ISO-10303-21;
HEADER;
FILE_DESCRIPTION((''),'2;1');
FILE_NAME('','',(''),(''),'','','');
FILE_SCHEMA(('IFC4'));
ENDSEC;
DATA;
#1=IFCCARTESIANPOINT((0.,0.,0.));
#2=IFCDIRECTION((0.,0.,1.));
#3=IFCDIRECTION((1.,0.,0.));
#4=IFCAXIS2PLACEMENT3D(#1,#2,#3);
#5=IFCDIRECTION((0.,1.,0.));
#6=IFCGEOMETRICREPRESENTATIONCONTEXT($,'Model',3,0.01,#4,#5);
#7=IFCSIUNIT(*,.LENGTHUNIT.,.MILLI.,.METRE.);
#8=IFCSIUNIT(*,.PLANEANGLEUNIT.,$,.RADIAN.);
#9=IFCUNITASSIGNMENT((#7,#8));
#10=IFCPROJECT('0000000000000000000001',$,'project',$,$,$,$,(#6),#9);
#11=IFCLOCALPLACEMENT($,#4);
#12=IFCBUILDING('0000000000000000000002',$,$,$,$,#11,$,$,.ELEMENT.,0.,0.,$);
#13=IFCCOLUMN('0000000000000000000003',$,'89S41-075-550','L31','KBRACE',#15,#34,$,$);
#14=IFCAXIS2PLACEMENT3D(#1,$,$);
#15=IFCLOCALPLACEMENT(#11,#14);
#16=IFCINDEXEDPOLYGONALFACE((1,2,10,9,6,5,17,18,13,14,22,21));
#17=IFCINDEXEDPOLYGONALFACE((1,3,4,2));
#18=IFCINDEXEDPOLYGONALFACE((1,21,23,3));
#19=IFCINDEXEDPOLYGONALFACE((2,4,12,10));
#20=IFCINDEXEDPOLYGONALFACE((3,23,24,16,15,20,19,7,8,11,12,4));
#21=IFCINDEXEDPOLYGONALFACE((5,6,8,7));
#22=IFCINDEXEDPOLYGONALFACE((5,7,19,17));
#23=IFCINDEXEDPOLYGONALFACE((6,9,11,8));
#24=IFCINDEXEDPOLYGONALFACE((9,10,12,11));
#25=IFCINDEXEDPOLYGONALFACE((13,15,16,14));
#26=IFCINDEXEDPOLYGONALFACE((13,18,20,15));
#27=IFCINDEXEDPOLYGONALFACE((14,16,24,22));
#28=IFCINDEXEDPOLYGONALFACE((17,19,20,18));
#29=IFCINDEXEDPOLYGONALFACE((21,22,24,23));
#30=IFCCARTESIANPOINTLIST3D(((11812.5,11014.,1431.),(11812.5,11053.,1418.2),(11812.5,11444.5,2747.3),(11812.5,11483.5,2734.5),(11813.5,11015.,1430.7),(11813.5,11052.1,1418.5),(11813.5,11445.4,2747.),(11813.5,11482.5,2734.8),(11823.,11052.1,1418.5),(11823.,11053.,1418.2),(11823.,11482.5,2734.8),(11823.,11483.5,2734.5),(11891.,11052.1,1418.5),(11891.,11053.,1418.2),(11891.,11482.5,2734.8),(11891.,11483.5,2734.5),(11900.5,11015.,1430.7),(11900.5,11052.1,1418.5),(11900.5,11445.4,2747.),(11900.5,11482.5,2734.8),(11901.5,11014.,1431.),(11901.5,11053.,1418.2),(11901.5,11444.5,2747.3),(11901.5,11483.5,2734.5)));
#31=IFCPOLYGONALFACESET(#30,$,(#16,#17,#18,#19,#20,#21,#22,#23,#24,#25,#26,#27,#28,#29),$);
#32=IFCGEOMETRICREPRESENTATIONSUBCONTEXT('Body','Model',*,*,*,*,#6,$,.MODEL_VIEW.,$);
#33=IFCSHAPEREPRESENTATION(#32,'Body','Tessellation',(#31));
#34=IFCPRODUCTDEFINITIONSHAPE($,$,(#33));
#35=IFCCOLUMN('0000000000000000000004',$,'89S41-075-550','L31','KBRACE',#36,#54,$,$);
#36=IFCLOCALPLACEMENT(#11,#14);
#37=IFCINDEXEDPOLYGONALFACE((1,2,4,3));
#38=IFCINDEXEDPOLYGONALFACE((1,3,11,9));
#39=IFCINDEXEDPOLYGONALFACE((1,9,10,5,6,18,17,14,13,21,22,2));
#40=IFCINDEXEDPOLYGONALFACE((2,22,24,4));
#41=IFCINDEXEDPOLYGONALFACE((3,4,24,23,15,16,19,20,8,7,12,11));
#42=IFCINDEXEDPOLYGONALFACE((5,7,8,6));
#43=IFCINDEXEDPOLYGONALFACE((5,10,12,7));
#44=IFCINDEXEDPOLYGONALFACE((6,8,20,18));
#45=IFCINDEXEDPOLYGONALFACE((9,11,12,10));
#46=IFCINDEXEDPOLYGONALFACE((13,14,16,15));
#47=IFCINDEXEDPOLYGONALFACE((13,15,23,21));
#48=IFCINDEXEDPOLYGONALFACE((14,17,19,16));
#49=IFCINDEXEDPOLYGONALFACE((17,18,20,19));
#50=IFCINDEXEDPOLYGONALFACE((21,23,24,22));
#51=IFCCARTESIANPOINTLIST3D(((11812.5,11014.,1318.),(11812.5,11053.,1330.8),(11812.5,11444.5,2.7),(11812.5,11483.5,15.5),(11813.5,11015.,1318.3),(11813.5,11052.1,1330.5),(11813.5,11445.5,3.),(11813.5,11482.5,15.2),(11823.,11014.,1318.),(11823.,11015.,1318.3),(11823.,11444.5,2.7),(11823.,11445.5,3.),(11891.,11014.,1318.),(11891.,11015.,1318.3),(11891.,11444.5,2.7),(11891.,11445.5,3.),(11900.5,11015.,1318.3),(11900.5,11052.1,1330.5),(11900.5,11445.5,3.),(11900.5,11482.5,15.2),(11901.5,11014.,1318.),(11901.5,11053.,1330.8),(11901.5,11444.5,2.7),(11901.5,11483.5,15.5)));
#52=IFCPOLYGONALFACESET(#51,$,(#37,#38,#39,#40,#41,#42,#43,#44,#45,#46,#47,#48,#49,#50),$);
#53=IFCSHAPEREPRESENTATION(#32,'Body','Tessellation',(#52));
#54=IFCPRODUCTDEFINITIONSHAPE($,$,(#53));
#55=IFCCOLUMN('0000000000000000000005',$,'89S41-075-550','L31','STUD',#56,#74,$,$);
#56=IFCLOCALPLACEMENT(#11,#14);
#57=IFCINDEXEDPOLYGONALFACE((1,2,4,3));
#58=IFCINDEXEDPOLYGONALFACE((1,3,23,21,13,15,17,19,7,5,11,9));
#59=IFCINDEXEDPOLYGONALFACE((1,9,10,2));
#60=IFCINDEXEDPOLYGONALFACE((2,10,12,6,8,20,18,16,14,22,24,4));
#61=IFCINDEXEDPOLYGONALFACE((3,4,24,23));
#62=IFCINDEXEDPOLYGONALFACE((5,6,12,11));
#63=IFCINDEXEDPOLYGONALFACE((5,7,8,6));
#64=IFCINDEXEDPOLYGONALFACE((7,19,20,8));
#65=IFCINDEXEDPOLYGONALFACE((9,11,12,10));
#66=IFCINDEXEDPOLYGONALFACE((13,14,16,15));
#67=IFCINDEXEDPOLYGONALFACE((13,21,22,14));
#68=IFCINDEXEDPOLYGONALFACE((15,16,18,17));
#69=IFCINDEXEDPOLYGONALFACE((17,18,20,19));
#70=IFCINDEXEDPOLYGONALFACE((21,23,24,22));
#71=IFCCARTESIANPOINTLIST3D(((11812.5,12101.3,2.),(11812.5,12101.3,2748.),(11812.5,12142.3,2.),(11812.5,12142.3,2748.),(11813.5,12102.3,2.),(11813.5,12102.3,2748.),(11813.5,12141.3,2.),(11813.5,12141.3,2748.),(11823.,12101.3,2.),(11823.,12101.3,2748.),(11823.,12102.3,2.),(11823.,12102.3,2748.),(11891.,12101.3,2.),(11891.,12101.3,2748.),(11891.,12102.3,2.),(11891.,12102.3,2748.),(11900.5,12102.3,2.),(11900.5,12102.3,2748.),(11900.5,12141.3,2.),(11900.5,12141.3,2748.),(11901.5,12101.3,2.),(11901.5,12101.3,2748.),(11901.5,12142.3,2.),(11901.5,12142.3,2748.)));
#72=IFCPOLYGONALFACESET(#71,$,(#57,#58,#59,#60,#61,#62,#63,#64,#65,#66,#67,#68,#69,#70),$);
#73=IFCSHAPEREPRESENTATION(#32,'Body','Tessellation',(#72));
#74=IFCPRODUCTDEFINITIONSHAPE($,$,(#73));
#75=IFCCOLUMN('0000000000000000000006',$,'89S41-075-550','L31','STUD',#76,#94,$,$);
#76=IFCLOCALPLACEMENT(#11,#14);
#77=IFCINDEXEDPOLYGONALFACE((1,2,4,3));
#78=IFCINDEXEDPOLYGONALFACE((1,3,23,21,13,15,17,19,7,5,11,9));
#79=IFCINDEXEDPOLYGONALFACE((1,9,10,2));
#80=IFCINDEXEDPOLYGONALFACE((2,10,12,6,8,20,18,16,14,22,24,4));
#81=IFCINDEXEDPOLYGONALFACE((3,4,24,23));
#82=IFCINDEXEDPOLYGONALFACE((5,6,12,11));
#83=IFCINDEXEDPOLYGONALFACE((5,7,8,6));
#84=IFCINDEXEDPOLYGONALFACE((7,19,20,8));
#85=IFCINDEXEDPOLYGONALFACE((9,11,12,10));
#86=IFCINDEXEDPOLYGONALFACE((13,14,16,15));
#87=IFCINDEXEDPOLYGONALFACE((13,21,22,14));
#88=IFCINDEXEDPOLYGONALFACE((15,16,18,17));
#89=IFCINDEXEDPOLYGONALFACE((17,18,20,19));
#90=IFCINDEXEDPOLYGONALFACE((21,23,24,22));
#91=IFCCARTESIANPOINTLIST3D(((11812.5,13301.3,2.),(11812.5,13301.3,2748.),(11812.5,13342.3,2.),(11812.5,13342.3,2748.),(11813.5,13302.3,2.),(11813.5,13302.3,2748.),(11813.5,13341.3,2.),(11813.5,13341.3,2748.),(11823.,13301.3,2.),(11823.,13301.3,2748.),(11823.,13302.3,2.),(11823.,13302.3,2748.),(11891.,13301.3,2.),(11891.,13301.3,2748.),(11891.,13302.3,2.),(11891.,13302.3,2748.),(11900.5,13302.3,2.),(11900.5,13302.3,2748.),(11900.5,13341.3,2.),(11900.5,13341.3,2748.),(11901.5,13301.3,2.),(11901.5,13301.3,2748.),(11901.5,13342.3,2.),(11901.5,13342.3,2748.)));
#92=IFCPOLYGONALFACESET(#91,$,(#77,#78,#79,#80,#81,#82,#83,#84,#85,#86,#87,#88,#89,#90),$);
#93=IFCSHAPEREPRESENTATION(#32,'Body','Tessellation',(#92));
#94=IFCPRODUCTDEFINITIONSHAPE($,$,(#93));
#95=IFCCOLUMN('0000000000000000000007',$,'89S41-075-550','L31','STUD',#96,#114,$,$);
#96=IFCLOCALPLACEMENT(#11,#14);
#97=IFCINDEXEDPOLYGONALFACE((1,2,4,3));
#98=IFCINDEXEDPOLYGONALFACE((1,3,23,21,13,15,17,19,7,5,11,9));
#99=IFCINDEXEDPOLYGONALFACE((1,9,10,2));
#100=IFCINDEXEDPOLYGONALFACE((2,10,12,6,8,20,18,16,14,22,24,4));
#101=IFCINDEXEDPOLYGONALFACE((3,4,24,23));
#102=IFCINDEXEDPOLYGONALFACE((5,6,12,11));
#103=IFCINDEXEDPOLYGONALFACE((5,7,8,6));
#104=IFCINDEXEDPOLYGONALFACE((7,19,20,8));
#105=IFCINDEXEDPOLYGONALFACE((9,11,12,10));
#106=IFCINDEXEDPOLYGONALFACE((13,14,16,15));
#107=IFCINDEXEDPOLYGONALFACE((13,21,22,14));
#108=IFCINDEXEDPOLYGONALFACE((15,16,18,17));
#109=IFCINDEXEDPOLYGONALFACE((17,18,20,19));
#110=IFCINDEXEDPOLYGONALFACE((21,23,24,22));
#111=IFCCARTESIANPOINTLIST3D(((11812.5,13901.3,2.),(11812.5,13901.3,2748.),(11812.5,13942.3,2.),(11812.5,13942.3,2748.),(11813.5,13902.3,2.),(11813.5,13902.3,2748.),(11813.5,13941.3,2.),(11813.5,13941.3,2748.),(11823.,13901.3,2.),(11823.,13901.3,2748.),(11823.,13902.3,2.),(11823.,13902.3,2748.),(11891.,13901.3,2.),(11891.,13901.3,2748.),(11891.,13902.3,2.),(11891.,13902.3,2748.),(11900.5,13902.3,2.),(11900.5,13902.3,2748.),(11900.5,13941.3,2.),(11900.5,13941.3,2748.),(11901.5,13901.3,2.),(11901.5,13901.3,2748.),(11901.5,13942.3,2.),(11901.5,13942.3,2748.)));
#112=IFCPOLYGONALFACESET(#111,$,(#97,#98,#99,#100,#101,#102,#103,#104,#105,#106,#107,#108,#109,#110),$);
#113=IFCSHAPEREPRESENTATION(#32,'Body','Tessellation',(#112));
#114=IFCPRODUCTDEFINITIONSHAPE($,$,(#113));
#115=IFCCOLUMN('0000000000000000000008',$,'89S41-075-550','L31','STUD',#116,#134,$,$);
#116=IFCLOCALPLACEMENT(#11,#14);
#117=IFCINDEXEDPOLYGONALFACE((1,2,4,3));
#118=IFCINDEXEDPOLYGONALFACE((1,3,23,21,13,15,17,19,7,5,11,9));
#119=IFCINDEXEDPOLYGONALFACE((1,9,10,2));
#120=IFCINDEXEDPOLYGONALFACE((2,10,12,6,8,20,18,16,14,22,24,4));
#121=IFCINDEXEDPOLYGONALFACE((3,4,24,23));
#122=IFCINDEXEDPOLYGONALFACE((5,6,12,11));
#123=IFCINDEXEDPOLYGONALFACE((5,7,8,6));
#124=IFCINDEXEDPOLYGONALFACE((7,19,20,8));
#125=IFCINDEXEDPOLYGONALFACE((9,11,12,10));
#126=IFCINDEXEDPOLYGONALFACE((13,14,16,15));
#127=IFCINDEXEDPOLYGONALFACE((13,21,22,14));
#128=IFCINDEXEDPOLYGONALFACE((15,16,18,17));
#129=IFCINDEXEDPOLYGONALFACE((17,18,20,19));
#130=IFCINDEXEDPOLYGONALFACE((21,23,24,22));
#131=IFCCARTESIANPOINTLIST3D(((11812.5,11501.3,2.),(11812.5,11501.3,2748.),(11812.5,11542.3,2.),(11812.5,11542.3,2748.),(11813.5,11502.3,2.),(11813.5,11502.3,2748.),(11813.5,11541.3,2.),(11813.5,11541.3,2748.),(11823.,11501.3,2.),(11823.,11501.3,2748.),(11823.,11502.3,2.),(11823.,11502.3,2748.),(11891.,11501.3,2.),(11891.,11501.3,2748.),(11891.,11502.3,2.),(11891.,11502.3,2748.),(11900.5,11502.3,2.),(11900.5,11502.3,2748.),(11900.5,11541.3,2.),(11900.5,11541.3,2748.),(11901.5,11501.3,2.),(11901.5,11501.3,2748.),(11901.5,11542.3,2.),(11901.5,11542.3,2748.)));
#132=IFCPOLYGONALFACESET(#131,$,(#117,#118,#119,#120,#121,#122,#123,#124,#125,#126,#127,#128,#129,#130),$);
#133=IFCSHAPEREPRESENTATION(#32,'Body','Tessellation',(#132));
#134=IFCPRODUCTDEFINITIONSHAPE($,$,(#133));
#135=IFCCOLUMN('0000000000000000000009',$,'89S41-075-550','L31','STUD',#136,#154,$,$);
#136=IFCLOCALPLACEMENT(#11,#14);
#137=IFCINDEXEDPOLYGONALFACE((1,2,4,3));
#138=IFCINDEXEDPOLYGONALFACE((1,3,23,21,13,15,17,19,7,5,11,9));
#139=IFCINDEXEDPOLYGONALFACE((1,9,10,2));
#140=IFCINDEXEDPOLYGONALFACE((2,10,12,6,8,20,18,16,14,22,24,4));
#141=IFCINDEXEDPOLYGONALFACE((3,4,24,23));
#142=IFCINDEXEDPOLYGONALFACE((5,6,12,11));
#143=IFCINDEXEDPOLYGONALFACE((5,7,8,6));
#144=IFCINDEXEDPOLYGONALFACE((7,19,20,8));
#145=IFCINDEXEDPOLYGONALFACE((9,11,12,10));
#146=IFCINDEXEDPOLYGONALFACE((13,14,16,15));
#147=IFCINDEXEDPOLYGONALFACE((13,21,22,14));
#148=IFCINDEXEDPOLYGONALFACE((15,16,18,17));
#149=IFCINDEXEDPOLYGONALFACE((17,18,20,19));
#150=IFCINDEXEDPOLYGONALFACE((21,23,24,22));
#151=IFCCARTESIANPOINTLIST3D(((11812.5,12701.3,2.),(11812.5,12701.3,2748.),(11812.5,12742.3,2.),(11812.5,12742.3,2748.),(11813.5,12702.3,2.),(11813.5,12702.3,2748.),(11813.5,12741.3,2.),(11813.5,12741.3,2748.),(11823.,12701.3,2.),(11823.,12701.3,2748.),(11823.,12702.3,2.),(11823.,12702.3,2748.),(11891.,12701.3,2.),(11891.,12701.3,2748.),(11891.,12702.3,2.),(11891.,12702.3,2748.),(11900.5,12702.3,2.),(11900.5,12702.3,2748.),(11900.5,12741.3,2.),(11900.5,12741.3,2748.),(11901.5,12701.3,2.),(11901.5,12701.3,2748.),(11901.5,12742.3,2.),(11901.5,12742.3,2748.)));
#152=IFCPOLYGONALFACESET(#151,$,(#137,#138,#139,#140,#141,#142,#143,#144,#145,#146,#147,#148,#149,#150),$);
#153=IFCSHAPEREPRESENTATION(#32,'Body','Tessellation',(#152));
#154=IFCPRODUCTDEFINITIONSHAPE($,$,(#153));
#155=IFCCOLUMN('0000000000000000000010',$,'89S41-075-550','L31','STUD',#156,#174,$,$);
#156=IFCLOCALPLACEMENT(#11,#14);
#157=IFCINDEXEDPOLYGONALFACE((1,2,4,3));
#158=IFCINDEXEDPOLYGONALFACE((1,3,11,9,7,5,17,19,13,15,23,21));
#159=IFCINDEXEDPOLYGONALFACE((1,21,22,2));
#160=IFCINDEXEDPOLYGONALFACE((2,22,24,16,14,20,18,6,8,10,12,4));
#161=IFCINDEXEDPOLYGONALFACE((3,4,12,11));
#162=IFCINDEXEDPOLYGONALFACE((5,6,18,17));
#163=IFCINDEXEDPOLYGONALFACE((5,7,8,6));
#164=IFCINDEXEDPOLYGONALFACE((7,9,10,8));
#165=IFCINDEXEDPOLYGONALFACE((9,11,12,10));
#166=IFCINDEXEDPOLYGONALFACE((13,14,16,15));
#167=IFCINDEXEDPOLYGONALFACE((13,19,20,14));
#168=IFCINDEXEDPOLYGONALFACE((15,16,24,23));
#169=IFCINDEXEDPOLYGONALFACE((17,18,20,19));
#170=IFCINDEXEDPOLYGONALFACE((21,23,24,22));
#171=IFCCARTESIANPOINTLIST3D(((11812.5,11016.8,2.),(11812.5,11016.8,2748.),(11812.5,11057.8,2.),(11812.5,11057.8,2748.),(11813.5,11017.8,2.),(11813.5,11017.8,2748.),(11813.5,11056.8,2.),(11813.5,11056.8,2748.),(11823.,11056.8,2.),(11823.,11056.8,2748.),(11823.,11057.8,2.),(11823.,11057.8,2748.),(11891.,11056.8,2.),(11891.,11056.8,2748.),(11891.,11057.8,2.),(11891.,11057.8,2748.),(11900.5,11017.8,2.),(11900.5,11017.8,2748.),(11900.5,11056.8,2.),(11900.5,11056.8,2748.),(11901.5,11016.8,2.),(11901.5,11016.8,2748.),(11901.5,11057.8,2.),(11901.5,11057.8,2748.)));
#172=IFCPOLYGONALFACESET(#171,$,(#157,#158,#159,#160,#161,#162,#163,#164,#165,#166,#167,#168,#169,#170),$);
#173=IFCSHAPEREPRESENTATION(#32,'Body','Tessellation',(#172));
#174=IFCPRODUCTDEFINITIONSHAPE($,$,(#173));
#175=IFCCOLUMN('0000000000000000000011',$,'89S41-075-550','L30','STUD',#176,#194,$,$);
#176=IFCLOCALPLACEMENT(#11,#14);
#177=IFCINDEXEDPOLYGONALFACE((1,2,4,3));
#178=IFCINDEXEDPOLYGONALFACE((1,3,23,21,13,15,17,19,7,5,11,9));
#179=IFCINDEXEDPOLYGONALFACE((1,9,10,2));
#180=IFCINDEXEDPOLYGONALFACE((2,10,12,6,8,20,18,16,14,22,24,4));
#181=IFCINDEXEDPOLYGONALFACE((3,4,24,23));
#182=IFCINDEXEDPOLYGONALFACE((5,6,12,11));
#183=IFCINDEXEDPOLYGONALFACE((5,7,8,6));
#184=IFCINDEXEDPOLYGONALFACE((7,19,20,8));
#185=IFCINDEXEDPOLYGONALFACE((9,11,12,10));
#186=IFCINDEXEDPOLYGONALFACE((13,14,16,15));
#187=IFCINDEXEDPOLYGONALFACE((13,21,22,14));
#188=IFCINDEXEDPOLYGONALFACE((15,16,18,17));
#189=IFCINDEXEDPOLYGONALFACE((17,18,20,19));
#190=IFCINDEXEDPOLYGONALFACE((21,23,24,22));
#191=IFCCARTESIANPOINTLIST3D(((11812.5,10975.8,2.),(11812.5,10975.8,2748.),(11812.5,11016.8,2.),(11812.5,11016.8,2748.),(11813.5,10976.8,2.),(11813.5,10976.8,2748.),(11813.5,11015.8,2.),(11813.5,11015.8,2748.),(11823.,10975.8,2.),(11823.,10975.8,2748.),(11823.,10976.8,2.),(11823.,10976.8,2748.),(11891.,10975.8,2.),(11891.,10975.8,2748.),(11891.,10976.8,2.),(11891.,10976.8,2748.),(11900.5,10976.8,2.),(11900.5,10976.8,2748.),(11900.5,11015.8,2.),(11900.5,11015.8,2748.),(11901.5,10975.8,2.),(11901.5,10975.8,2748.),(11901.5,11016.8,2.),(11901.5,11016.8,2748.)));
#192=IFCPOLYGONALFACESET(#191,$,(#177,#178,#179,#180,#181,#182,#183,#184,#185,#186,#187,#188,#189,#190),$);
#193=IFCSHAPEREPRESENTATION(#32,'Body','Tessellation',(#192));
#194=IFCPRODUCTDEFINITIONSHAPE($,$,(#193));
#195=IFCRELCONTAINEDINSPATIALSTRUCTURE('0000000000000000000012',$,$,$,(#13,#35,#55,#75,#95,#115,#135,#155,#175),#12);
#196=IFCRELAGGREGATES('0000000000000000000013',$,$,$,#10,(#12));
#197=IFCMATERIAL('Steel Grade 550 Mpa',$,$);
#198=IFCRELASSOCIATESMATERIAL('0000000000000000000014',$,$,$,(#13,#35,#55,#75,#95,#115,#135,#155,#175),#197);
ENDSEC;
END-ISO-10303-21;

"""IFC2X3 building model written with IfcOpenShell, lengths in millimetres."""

from ifc_helpers import new_model, si_unit, direction, frame, origin, origin_with_axes, origin_2d_with_axis, place, context, subcontext, project, spatial, c_section, extrude, source, transform, mapped, material, element, save


model = new_model("IFC2X3")

# Units and contexts
model_context = context("Model", 3, precision=0.01, world=origin_with_axes(), true_north=direction((0.0, 1.0, 0.0)))
body_context = subcontext(model_context, "Body", "Model", "MODEL_VIEW")
ifc_project = project(units=[si_unit("LENGTHUNIT", "METRE", prefix="MILLI"), si_unit("PLANEANGLEUNIT", "RADIAN")], contexts=[model_context])

# Building
building_placement = place(None, origin_with_axes())
building = spatial("IfcBuilding", under=ifc_project, at=building_placement, CompositionType="ELEMENT", ElevationOfRefHeight=0.0, ElevationOfTerrain=0.0)

# Columns
ifc_material = material(Name="Steel Grade 550 Mpa")
shared_shape_1 = source(origin(), body_context, "Body", "SweptSolid", [
    extrude(c_section(Depth=89.0, Width=41.0, WallThickness=1.0, Girth=10.5, at=origin_2d_with_axis()), origin_with_axes(), (0.0, 0.0, 1.0), 1384.9),
])
column_1_placement = place(None, frame((11857.0, 11033.5, 1424.6), z_axis=(0.0, 0.310822, 0.950468), x_axis=(0.0, 0.950468, -0.310822)))
element("IfcColumn", 1, at=column_1_placement, inside=building, material=ifc_material, Name="89S41-075-550", Description="L31", ObjectType="KBRACE", context=body_context, shape_type="MappedRepresentation", body=[
    mapped(shared_shape_1, transform((0.0, 0.0, 0.0), scale=1.0)),
])
shared_shape_2 = source(origin(), body_context, "Body", "SweptSolid", [
    extrude(c_section(Depth=89.0, Width=41.0, WallThickness=1.0, Girth=10.5, at=origin_2d_with_axis()), origin_with_axes(), (0.0, 0.0, 1.0), 1384.0),
])
column_2_placement = place(None, frame((11857.0, 11464.0, 9.1), z_axis=(0.0, -0.31104, 0.950397), x_axis=(0.0, -0.950397, -0.31104)))
element("IfcColumn", 2, at=column_2_placement, inside=building, material=ifc_material, Name="89S41-075-550", Description="L31", ObjectType="KBRACE", context=body_context, shape_type="MappedRepresentation", body=[
    mapped(shared_shape_2, transform((0.0, 0.0, 0.0), scale=1.0)),
])
shared_shape_3 = source(origin(), body_context, "Body", "SweptSolid", [
    extrude(c_section(Depth=89.0, Width=41.0, WallThickness=1.0, Girth=10.5, at=origin_2d_with_axis()), origin_with_axes(), (0.0, 0.0, 1.0), 2746.0),
])
column_3_placement = place(None, frame((11857.0, 12121.8, 2.0), z_axis=(0.0, 0.0, 1.0), x_axis=(0.0, -1.0, 0.0)))
element("IfcColumn", 3, at=column_3_placement, inside=building, material=ifc_material, Name="89S41-075-550", Description="L31", ObjectType="STUD", context=body_context, shape_type="MappedRepresentation", body=[
    mapped(shared_shape_3, transform((0.0, 0.0, 0.0), scale=1.0)),
])
shared_shape_4 = source(origin(), body_context, "Body", "SweptSolid", [
    extrude(c_section(Depth=89.0, Width=41.0, WallThickness=1.0, Girth=10.5, at=origin_2d_with_axis()), origin_with_axes(), (0.0, 0.0, 1.0), 2746.0),
])
column_4_placement = place(None, frame((11857.0, 13321.8, 2.0), z_axis=(0.0, 0.0, 1.0), x_axis=(0.0, -1.0, 0.0)))
element("IfcColumn", 4, at=column_4_placement, inside=building, material=ifc_material, Name="89S41-075-550", Description="L31", ObjectType="STUD", context=body_context, shape_type="MappedRepresentation", body=[
    mapped(shared_shape_4, transform((0.0, 0.0, 0.0), scale=1.0)),
])
shared_shape_5 = source(origin(), body_context, "Body", "SweptSolid", [
    extrude(c_section(Depth=89.0, Width=41.0, WallThickness=1.0, Girth=10.5, at=origin_2d_with_axis()), origin_with_axes(), (0.0, 0.0, 1.0), 2746.0),
])
column_5_placement = place(None, frame((11857.0, 13921.8, 2.0), z_axis=(0.0, 0.0, 1.0), x_axis=(0.0, -1.0, 0.0)))
element("IfcColumn", 5, at=column_5_placement, inside=building, material=ifc_material, Name="89S41-075-550", Description="L31", ObjectType="STUD", context=body_context, shape_type="MappedRepresentation", body=[
    mapped(shared_shape_5, transform((0.0, 0.0, 0.0), scale=1.0)),
])
shared_shape_6 = source(origin(), body_context, "Body", "SweptSolid", [
    extrude(c_section(Depth=89.0, Width=41.0, WallThickness=1.0, Girth=10.5, at=origin_2d_with_axis()), origin_with_axes(), (0.0, 0.0, 1.0), 2746.0),
])
column_6_placement = place(None, frame((11857.0, 11521.8, 2.0), z_axis=(0.0, 0.0, 1.0), x_axis=(0.0, -1.0, 0.0)))
element("IfcColumn", 6, at=column_6_placement, inside=building, material=ifc_material, Name="89S41-075-550", Description="L31", ObjectType="STUD", context=body_context, shape_type="MappedRepresentation", body=[
    mapped(shared_shape_6, transform((0.0, 0.0, 0.0), scale=1.0)),
])
shared_shape_7 = source(origin(), body_context, "Body", "SweptSolid", [
    extrude(c_section(Depth=89.0, Width=41.0, WallThickness=1.0, Girth=10.5, at=origin_2d_with_axis()), origin_with_axes(), (0.0, 0.0, 1.0), 2746.0),
])
column_7_placement = place(None, frame((11857.0, 12721.8, 2.0), z_axis=(0.0, 0.0, 1.0), x_axis=(0.0, -1.0, 0.0)))
element("IfcColumn", 7, at=column_7_placement, inside=building, material=ifc_material, Name="89S41-075-550", Description="L31", ObjectType="STUD", context=body_context, shape_type="MappedRepresentation", body=[
    mapped(shared_shape_7, transform((0.0, 0.0, 0.0), scale=1.0)),
])
shared_shape_8 = source(origin(), body_context, "Body", "SweptSolid", [
    extrude(c_section(Depth=89.0, Width=41.0, WallThickness=1.0, Girth=10.5, at=origin_2d_with_axis()), origin_with_axes(), (0.0, 0.0, 1.0), 2746.0),
])
column_8_placement = place(None, frame((11857.0, 11037.3, 2.0), z_axis=(0.0, 0.0, 1.0), x_axis=(0.0, 1.0, 0.0)))
element("IfcColumn", 8, at=column_8_placement, inside=building, material=ifc_material, Name="89S41-075-550", Description="L31", ObjectType="STUD", context=body_context, shape_type="MappedRepresentation", body=[
    mapped(shared_shape_8, transform((0.0, 0.0, 0.0), scale=1.0)),
])
shared_shape_9 = source(origin(), body_context, "Body", "SweptSolid", [
    extrude(c_section(Depth=89.0, Width=41.0, WallThickness=1.0, Girth=10.5, at=origin_2d_with_axis()), origin_with_axes(), (0.0, 0.0, 1.0), 2746.0),
])
column_9_placement = place(None, frame((11857.0, 10996.3, 2.0), z_axis=(0.0, 0.0, 1.0), x_axis=(0.0, -1.0, 0.0)))
element("IfcColumn", 9, at=column_9_placement, inside=building, material=ifc_material, Name="89S41-075-550", Description="L30", ObjectType="STUD", context=body_context, shape_type="MappedRepresentation", body=[
    mapped(shared_shape_9, transform((0.0, 0.0, 0.0), scale=1.0)),
])

save(model, "model.ifc")
